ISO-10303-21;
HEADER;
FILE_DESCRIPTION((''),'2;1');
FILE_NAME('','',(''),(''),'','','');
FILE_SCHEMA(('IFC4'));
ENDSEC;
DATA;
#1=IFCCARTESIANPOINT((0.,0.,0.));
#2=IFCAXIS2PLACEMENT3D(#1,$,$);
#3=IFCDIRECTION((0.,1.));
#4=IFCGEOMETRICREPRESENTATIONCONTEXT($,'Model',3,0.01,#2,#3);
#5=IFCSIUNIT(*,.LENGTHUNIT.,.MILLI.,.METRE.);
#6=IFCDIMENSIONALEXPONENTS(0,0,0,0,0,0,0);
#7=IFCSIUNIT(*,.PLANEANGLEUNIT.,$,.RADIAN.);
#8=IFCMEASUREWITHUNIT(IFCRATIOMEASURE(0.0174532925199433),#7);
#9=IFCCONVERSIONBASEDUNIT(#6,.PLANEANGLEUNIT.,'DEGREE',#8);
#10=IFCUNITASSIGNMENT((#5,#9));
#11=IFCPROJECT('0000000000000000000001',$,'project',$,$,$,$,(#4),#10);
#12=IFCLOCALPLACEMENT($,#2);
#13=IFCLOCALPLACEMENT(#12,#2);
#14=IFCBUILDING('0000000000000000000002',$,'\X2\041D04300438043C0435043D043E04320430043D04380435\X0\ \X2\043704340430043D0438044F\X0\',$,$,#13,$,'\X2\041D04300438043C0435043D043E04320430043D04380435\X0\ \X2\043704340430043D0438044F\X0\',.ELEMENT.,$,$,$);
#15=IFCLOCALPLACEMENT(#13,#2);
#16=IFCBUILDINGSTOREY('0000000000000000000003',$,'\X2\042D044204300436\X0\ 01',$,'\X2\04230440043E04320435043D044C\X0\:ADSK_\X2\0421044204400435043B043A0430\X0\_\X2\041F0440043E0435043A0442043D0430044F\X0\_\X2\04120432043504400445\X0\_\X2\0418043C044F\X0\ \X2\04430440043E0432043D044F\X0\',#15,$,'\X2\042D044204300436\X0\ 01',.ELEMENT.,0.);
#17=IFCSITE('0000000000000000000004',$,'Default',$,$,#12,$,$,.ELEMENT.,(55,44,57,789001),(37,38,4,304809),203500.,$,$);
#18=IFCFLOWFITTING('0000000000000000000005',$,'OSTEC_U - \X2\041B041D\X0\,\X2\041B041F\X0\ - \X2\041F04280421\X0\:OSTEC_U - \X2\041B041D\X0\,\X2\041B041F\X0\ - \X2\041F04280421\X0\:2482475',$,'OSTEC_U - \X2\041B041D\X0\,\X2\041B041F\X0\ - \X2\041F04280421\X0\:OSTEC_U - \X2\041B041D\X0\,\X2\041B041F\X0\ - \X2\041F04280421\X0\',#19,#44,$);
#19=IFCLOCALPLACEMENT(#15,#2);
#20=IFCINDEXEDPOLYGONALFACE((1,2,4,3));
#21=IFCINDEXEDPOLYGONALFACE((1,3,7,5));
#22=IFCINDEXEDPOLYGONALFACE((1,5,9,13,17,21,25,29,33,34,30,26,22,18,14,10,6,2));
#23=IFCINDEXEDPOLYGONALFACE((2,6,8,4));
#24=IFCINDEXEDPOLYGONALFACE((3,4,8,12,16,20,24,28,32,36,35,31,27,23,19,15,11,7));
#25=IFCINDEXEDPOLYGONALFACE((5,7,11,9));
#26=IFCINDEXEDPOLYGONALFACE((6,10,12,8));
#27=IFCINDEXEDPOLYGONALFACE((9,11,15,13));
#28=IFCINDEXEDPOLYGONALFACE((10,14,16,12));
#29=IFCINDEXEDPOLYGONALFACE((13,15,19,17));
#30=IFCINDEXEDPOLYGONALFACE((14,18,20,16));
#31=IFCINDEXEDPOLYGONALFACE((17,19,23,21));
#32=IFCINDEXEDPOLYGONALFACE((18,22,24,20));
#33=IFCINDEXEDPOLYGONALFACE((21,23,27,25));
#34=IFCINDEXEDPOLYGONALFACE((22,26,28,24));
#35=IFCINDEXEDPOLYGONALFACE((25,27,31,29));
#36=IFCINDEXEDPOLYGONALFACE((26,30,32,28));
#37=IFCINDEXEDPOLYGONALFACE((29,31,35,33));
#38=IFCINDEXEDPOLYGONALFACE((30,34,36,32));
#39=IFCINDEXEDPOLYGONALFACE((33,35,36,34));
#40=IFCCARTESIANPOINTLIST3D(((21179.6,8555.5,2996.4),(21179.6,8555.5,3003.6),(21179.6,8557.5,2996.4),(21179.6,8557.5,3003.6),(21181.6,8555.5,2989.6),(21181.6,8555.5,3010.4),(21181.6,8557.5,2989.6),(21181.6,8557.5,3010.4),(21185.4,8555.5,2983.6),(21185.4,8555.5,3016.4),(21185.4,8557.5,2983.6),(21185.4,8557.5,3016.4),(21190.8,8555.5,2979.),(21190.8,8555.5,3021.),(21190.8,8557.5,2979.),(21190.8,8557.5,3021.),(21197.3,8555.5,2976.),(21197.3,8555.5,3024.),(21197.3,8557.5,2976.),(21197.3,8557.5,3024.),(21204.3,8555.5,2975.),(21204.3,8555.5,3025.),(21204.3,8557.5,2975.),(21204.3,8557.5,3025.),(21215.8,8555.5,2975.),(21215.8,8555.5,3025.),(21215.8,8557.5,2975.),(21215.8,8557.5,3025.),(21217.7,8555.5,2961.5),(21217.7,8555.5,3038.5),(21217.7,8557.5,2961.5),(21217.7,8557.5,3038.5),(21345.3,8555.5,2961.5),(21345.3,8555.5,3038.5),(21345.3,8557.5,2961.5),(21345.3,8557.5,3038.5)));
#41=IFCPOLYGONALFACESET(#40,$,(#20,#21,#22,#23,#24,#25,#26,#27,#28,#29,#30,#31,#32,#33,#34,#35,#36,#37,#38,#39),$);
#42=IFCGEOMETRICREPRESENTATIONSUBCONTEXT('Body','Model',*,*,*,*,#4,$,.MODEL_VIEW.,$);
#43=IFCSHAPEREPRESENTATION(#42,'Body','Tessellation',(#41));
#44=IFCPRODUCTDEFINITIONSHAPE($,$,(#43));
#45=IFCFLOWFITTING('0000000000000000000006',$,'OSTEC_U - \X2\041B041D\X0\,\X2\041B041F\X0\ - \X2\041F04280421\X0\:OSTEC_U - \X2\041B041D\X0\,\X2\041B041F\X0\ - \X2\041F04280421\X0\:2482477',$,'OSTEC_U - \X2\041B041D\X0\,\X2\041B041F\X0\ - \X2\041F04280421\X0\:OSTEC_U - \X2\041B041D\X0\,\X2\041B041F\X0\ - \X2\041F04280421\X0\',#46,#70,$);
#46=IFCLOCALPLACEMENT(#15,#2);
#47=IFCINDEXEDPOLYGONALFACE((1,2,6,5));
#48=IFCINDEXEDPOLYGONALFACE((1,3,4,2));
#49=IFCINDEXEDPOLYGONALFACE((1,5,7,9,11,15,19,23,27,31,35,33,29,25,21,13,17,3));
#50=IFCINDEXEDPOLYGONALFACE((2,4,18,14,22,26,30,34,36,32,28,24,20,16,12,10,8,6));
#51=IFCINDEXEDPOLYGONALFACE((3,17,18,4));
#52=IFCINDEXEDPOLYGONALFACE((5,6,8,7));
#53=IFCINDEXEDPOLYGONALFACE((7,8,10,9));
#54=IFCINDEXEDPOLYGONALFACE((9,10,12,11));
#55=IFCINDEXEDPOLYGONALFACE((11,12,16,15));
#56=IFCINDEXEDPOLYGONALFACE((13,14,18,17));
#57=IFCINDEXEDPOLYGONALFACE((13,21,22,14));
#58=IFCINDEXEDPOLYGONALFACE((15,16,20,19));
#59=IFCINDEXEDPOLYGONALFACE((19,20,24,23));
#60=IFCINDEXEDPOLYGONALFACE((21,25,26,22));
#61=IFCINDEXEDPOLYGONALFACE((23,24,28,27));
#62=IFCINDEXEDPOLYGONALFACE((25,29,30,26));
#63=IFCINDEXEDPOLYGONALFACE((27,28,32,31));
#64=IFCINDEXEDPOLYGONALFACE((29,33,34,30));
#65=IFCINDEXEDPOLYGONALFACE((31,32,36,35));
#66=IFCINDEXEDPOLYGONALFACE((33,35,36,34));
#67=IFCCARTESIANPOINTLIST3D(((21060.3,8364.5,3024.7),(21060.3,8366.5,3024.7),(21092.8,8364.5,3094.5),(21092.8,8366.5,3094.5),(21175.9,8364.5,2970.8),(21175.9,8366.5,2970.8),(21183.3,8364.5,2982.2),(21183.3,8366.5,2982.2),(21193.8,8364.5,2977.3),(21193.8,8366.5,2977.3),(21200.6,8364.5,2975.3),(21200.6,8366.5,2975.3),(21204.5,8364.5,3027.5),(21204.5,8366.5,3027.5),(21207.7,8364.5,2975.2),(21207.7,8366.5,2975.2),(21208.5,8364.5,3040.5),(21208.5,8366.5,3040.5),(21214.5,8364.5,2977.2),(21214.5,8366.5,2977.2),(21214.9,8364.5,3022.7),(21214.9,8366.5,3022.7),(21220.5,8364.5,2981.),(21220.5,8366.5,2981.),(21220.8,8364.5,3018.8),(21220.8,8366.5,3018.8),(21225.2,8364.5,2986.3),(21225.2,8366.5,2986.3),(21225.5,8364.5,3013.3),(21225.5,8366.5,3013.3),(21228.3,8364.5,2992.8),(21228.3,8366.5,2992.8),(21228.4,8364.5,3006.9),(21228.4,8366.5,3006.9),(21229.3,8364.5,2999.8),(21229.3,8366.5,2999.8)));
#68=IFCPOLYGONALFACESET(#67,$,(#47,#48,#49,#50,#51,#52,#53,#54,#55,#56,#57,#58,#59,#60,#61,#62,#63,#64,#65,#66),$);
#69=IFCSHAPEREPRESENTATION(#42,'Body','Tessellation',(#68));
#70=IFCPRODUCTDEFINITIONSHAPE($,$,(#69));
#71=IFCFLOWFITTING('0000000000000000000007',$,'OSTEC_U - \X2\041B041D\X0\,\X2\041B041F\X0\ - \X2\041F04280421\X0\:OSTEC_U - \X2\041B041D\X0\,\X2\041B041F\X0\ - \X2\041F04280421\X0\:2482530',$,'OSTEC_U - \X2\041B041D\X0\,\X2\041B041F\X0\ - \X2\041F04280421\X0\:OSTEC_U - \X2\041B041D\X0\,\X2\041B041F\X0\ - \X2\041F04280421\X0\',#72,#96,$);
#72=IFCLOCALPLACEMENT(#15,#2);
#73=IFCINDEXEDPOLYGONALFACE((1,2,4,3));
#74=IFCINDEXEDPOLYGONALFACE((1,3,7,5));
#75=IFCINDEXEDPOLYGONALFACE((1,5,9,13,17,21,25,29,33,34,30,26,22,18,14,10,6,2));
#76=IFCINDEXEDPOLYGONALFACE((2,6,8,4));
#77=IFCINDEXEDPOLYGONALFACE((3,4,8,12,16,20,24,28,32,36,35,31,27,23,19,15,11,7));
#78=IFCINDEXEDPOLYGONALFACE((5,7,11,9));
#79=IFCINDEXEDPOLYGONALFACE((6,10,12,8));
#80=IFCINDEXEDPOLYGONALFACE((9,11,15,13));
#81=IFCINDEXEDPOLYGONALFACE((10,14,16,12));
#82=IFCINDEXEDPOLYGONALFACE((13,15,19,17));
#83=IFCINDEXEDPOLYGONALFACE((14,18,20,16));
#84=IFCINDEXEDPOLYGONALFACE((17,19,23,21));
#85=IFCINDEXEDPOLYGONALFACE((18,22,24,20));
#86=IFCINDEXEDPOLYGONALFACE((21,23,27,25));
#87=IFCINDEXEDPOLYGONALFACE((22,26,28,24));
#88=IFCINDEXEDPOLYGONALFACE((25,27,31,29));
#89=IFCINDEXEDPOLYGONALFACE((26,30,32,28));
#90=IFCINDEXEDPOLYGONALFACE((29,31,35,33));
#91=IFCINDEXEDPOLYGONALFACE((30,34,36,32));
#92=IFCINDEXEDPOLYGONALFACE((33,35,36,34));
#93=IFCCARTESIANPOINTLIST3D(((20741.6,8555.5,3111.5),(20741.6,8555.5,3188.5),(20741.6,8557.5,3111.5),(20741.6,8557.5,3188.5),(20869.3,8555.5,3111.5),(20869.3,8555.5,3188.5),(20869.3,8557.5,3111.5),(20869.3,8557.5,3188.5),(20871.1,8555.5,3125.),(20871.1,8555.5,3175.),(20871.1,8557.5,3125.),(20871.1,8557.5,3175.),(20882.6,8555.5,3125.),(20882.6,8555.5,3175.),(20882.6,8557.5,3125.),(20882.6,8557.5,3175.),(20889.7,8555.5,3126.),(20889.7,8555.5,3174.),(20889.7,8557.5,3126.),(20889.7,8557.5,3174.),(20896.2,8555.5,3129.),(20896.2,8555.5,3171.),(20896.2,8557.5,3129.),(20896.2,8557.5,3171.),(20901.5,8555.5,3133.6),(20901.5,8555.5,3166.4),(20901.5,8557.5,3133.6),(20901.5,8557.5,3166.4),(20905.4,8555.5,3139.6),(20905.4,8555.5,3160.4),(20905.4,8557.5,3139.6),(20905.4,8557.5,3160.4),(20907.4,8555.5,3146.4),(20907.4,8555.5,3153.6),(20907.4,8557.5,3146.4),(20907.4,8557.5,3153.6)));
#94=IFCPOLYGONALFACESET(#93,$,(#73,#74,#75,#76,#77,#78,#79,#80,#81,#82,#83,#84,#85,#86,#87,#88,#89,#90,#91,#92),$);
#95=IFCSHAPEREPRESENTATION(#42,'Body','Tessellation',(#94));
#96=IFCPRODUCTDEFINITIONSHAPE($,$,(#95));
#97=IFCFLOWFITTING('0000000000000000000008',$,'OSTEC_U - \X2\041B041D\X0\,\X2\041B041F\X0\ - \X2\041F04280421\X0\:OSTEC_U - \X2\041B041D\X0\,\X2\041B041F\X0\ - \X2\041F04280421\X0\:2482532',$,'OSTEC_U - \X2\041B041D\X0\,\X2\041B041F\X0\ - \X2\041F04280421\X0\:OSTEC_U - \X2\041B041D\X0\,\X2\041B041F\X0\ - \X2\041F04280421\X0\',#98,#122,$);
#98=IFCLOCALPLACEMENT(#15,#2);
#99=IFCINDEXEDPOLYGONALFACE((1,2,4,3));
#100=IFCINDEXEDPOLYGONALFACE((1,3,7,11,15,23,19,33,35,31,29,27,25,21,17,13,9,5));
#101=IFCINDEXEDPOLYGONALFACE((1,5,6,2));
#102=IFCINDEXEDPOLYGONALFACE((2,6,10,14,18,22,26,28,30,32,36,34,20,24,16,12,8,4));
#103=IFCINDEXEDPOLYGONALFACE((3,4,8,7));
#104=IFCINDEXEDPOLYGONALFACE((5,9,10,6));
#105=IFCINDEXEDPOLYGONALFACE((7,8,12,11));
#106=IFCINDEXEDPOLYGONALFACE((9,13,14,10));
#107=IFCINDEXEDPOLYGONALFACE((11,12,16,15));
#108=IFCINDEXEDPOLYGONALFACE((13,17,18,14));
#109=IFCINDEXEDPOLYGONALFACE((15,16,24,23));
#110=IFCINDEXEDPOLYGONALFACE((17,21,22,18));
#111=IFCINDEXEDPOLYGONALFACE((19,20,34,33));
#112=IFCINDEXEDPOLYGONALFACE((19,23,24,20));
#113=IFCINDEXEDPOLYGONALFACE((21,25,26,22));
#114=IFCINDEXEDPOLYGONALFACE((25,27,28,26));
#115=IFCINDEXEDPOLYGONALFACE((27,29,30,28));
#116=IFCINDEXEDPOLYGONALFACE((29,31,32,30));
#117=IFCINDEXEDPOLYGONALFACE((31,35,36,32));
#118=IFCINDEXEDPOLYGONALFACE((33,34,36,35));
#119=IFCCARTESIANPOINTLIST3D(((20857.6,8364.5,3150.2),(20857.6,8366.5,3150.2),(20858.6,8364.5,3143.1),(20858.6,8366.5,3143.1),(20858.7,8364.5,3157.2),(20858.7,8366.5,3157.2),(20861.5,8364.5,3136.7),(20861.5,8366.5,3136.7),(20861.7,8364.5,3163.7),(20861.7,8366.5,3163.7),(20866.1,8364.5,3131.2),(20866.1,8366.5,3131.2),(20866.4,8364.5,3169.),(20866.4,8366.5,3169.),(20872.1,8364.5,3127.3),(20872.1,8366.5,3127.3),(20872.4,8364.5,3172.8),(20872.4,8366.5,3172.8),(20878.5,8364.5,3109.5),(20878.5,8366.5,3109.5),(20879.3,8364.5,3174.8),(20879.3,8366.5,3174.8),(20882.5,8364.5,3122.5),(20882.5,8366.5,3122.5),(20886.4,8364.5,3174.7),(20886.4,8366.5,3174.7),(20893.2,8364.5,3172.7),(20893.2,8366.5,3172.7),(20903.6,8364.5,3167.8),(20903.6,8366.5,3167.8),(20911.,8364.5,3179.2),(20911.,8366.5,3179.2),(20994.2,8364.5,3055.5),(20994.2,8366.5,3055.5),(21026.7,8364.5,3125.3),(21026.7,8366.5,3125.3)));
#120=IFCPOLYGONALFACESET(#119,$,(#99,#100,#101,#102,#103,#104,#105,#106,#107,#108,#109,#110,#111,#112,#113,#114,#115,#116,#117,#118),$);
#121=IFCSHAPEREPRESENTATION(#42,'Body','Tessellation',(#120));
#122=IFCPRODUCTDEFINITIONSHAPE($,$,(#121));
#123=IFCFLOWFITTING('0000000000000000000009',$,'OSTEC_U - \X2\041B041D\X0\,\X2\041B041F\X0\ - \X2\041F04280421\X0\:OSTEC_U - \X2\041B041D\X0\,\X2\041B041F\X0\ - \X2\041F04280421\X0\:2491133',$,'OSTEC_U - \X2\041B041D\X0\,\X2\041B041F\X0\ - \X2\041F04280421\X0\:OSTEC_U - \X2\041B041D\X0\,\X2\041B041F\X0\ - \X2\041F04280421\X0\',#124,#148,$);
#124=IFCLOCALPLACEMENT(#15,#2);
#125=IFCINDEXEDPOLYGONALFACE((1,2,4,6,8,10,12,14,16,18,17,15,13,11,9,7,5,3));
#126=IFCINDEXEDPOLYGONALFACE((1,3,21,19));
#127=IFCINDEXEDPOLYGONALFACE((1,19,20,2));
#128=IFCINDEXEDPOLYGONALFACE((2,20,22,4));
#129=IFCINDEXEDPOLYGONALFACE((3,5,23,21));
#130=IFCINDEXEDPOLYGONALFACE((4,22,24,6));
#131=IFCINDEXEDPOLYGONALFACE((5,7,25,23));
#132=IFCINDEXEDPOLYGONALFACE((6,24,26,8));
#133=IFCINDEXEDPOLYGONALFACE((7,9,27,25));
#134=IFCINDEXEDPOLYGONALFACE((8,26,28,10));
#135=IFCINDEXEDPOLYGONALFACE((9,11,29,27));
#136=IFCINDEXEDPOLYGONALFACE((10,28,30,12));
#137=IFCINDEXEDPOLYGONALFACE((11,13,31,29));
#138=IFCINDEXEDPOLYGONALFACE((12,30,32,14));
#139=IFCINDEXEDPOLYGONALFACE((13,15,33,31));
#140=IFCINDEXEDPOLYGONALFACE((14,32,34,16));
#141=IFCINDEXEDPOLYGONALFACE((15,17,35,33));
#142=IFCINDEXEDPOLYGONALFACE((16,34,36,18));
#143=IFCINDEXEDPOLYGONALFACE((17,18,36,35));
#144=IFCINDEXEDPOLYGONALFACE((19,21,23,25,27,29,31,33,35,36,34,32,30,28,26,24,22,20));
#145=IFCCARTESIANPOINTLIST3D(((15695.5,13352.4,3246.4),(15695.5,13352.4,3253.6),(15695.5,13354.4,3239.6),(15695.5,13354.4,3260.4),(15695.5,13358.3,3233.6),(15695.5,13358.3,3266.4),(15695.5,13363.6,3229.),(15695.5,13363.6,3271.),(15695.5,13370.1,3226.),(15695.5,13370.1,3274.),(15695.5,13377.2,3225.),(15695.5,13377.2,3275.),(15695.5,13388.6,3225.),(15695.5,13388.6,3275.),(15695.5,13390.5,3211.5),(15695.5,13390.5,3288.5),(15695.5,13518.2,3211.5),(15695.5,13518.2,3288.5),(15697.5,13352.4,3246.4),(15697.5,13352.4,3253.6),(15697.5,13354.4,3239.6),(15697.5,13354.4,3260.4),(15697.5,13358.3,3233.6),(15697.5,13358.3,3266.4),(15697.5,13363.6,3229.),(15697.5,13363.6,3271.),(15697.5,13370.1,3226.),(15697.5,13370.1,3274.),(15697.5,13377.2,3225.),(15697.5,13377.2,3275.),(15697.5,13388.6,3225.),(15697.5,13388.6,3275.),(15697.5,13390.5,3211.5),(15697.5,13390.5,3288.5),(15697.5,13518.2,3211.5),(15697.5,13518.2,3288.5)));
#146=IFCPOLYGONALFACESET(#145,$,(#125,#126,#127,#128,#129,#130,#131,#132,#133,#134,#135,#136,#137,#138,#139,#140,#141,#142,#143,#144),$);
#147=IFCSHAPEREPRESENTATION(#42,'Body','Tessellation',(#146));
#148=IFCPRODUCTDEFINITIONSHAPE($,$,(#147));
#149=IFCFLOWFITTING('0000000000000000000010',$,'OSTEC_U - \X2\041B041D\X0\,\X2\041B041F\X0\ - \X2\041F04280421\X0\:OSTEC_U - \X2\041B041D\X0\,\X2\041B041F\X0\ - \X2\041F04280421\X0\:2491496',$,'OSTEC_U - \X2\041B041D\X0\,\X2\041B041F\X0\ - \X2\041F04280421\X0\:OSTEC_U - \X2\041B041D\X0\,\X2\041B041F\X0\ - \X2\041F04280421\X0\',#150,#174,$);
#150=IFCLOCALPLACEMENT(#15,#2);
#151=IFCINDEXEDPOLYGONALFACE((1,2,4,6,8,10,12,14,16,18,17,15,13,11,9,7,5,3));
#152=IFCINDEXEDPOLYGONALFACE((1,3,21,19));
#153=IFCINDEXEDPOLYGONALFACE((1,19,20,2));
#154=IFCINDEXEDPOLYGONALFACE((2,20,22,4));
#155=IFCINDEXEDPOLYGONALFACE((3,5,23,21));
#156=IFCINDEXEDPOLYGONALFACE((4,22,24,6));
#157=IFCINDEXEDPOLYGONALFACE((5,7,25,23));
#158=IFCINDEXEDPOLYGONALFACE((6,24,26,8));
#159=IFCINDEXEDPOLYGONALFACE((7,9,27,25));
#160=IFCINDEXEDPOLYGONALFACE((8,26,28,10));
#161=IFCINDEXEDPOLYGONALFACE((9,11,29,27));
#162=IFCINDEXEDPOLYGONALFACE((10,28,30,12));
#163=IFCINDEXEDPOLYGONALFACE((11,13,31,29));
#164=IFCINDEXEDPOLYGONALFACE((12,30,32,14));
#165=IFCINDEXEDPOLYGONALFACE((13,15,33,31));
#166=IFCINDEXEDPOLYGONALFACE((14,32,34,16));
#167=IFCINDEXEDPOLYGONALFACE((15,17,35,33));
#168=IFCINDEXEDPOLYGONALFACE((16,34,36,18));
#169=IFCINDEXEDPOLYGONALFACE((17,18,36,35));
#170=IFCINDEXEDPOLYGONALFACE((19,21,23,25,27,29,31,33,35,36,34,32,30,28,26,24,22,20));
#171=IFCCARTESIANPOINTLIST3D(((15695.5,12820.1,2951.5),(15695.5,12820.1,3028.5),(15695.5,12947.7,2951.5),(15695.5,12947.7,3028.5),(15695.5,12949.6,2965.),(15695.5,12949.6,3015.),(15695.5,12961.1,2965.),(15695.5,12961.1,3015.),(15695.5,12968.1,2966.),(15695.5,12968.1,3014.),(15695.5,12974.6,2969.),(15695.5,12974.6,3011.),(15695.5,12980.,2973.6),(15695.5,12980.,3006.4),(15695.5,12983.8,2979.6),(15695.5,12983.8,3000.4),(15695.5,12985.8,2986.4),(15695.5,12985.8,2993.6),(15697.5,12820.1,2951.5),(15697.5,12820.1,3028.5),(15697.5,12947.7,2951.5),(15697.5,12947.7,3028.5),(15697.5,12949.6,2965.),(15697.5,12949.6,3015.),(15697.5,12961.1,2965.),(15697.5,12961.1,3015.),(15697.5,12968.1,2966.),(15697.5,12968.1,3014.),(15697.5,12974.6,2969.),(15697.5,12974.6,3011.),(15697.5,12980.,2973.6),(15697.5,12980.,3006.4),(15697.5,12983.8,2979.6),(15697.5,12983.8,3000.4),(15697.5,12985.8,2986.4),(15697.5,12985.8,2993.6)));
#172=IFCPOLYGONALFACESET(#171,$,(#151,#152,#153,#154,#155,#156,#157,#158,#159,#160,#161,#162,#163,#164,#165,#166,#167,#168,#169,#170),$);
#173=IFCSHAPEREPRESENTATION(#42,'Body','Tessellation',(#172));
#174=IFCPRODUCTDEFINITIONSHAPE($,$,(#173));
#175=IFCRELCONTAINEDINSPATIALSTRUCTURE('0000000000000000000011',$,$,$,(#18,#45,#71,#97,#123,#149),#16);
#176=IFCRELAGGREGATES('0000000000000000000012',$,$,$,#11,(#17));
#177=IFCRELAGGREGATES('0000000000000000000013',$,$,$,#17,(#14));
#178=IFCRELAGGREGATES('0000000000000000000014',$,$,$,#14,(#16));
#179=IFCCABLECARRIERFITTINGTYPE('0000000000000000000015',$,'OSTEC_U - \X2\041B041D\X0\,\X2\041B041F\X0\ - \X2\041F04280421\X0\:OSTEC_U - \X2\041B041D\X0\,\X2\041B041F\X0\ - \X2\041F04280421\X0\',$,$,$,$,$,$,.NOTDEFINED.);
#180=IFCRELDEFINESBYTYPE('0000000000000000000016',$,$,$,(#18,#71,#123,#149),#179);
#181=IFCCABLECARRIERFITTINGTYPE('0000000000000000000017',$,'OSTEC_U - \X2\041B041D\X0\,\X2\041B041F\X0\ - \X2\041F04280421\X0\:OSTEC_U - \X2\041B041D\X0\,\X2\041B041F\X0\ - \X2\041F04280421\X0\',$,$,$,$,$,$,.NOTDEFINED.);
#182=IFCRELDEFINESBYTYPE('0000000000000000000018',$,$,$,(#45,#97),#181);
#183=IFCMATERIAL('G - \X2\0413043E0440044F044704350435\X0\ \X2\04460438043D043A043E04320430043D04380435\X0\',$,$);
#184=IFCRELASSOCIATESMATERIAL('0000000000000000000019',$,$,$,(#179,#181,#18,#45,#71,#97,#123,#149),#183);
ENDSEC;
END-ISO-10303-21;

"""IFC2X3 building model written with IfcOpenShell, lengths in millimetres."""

from ifc_helpers import new_model, entity, si_unit, converted_unit, direction, frame, frame_2d, origin, place, context, subcontext, project, spatial, polyline, circle_curve, parameter, trimmed, segment, composite_curve, outline, extrude, source, transform, mapped, material, type_object, type_shapes, element, save


model = new_model("IFC2X3")

# Units and contexts
model_context = context("Model", 3, precision=0.01, world=origin(), true_north=direction((0.0, 1.0)))
body_context = subcontext(model_context, "Body", "Model", "MODEL_VIEW")
ifc_project = project(units=[si_unit("LENGTHUNIT", "METRE", prefix="MILLI"), converted_unit("PLANEANGLEUNIT", "DEGREE", entity("IfcRatioMeasure", 0.0174532925199433), si_unit("PLANEANGLEUNIT", "RADIAN"), dimensions=[0, 0, 0, 0, 0, 0, 0])], contexts=[model_context])

# Site, building, storey
site_placement = place(None, origin())
site = spatial("IfcSite", under=ifc_project, at=site_placement, Name="Default", CompositionType="ELEMENT", RefLatitude=(55, 44, 57, 789001), RefLongitude=(37, 38, 4, 304809), RefElevation=203500.0)
building_placement = place(site_placement, origin())
building = spatial("IfcBuilding", under=site, at=building_placement, Name="Наименование здания", LongName="Наименование здания", CompositionType="ELEMENT")
storey_placement = place(building_placement, origin())
storey = spatial("IfcBuildingStorey", under=building, at=storey_placement, Name="Этаж 01", ObjectType="Уровень:ADSK_Стрелка_Проектная_Вверх_Имя уровня", LongName="Этаж 01", CompositionType="ELEMENT", Elevation=0.0)

# Flow fittings
ifc_material = material(Name="G - Горячее цинкование")
cable_carrier_fitting_type_1 = type_object("IfcCableCarrierFittingType", Name="OSTEC_U - ЛН,ЛП - ПШС:OSTEC_U - ЛН,ЛП - ПШС", PredefinedType="NOTDEFINED", material=ifc_material)
shared_shape_1 = source(origin(), body_context, "Body", "SweptSolid", [
    extrude(outline(composite_curve([segment(trimmed(circle_curve(frame_2d((-41.5, 0.0), x_axis=(1.0, 0.0)), 25.0), [parameter(90.0)], [parameter(270.0)], True, "PARAMETER"), True, "CONTINUOUS"), segment(polyline([(-41.5, -25.0), (-30.0, -25.0)]), True, "CONTINUOUS"), segment(polyline([(-30.0, -25.0), (-28.1, -38.5)]), True, "CONTINUOUS"), segment(polyline([(-28.1, -38.5), (99.5, -38.5)]), True, "CONTINUOUS"), segment(polyline([(99.5, -38.5), (99.5, 38.5)]), True, "CONTINUOUS"), segment(polyline([(99.5, 38.5), (-28.1, 38.5)]), True, "CONTINUOUS"), segment(polyline([(-28.1, 38.5), (-30.0, 25.0)]), True, "CONTINUOUS"), segment(polyline([(-30.0, 25.0), (-41.5, 25.0)]), True, "CONTINUOUS")], self_intersect=False)), frame((41.5, 0.0, 0.0)), (0.0, 0.0, 1.0), 2.0),
])
type_shapes(cable_carrier_fitting_type_1, [shared_shape_1])
cable_carrier_fitting_type_2 = type_object("IfcCableCarrierFittingType", Name="OSTEC_U - ЛН,ЛП - ПШС:OSTEC_U - ЛН,ЛП - ПШС", PredefinedType="NOTDEFINED", material=ifc_material)
type_shapes(cable_carrier_fitting_type_2, [shared_shape_1])
flow_fitting_1_placement = place(storey_placement, frame((21204.3, 8555.5, 3000.0), z_axis=(0.0, 1.0, 0.0), x_axis=(1.0, 0.0, 0.0)))
element("IfcFlowFitting", 1, at=flow_fitting_1_placement, inside=storey, type_object=cable_carrier_fitting_type_1, material=ifc_material, Name="OSTEC_U - ЛН,ЛП - ПШС:OSTEC_U - ЛН,ЛП - ПШС:2482475", ObjectType="OSTEC_U - ЛН,ЛП - ПШС:OSTEC_U - ЛН,ЛП - ПШС", context=body_context, shape_type="MappedRepresentation", body=[
    mapped(shared_shape_1, transform((0.0, 0.0, 0.0), scale=1.0)),
])
flow_fitting_2_placement = place(storey_placement, frame((21204.3, 8366.5, 3000.0), z_axis=(0.0, -1.0, 0.0), x_axis=(-0.906308, 0.0, 0.422618)))
element("IfcFlowFitting", 2, at=flow_fitting_2_placement, inside=storey, type_object=cable_carrier_fitting_type_2, material=ifc_material, Name="OSTEC_U - ЛН,ЛП - ПШС:OSTEC_U - ЛН,ЛП - ПШС:2482477", ObjectType="OSTEC_U - ЛН,ЛП - ПШС:OSTEC_U - ЛН,ЛП - ПШС", context=body_context, shape_type="MappedRepresentation", body=[
    mapped(shared_shape_1, transform((0.0, 0.0, 0.0), scale=1.0)),
])
flow_fitting_3_placement = place(storey_placement, frame((20882.6, 8555.5, 3150.0), z_axis=(0.0, 1.0, 0.0), x_axis=(-1.0, 0.0, 0.0)))
element("IfcFlowFitting", 3, at=flow_fitting_3_placement, inside=storey, type_object=cable_carrier_fitting_type_1, material=ifc_material, Name="OSTEC_U - ЛН,ЛП - ПШС:OSTEC_U - ЛН,ЛП - ПШС:2482530", ObjectType="OSTEC_U - ЛН,ЛП - ПШС:OSTEC_U - ЛН,ЛП - ПШС", context=body_context, shape_type="MappedRepresentation", body=[
    mapped(shared_shape_1, transform((0.0, 0.0, 0.0), scale=1.0)),
])
flow_fitting_4_placement = place(storey_placement, frame((20882.6, 8366.5, 3150.0), z_axis=(0.0, -1.0, 0.0), x_axis=(0.906308, 0.0, -0.422618)))
element("IfcFlowFitting", 4, at=flow_fitting_4_placement, inside=storey, type_object=cable_carrier_fitting_type_2, material=ifc_material, Name="OSTEC_U - ЛН,ЛП - ПШС:OSTEC_U - ЛН,ЛП - ПШС:2482532", ObjectType="OSTEC_U - ЛН,ЛП - ПШС:OSTEC_U - ЛН,ЛП - ПШС", context=body_context, shape_type="MappedRepresentation", body=[
    mapped(shared_shape_1, transform((0.0, 0.0, 0.0), scale=1.0)),
])
for number, where, z_axis, x_axis, name in (
    (5, (15695.5, 13377.1, 3250.0), (1.0, 0.0, 0.0), (0.0, 1.0, 0.0), "OSTEC_U - ЛН,ЛП - ПШС:OSTEC_U - ЛН,ЛП - ПШС:2491133"),
    (6, (15695.5, 12961.1, 2990.0), (1.0, 0.0, 0.0), (0.0, -1.0, 0.0), "OSTEC_U - ЛН,ЛП - ПШС:OSTEC_U - ЛН,ЛП - ПШС:2491496"),
):
    element("IfcFlowFitting", number, at=place(storey_placement, frame(where, z_axis=z_axis, x_axis=x_axis)), inside=storey, type_object=cable_carrier_fitting_type_1, material=ifc_material, Name=name, ObjectType="OSTEC_U - ЛН,ЛП - ПШС:OSTEC_U - ЛН,ЛП - ПШС", context=body_context, shape_type="MappedRepresentation", body=[
        mapped(shared_shape_1, transform((0.0, 0.0, 0.0), scale=1.0)),
    ])

save(model, "model.ifc")
